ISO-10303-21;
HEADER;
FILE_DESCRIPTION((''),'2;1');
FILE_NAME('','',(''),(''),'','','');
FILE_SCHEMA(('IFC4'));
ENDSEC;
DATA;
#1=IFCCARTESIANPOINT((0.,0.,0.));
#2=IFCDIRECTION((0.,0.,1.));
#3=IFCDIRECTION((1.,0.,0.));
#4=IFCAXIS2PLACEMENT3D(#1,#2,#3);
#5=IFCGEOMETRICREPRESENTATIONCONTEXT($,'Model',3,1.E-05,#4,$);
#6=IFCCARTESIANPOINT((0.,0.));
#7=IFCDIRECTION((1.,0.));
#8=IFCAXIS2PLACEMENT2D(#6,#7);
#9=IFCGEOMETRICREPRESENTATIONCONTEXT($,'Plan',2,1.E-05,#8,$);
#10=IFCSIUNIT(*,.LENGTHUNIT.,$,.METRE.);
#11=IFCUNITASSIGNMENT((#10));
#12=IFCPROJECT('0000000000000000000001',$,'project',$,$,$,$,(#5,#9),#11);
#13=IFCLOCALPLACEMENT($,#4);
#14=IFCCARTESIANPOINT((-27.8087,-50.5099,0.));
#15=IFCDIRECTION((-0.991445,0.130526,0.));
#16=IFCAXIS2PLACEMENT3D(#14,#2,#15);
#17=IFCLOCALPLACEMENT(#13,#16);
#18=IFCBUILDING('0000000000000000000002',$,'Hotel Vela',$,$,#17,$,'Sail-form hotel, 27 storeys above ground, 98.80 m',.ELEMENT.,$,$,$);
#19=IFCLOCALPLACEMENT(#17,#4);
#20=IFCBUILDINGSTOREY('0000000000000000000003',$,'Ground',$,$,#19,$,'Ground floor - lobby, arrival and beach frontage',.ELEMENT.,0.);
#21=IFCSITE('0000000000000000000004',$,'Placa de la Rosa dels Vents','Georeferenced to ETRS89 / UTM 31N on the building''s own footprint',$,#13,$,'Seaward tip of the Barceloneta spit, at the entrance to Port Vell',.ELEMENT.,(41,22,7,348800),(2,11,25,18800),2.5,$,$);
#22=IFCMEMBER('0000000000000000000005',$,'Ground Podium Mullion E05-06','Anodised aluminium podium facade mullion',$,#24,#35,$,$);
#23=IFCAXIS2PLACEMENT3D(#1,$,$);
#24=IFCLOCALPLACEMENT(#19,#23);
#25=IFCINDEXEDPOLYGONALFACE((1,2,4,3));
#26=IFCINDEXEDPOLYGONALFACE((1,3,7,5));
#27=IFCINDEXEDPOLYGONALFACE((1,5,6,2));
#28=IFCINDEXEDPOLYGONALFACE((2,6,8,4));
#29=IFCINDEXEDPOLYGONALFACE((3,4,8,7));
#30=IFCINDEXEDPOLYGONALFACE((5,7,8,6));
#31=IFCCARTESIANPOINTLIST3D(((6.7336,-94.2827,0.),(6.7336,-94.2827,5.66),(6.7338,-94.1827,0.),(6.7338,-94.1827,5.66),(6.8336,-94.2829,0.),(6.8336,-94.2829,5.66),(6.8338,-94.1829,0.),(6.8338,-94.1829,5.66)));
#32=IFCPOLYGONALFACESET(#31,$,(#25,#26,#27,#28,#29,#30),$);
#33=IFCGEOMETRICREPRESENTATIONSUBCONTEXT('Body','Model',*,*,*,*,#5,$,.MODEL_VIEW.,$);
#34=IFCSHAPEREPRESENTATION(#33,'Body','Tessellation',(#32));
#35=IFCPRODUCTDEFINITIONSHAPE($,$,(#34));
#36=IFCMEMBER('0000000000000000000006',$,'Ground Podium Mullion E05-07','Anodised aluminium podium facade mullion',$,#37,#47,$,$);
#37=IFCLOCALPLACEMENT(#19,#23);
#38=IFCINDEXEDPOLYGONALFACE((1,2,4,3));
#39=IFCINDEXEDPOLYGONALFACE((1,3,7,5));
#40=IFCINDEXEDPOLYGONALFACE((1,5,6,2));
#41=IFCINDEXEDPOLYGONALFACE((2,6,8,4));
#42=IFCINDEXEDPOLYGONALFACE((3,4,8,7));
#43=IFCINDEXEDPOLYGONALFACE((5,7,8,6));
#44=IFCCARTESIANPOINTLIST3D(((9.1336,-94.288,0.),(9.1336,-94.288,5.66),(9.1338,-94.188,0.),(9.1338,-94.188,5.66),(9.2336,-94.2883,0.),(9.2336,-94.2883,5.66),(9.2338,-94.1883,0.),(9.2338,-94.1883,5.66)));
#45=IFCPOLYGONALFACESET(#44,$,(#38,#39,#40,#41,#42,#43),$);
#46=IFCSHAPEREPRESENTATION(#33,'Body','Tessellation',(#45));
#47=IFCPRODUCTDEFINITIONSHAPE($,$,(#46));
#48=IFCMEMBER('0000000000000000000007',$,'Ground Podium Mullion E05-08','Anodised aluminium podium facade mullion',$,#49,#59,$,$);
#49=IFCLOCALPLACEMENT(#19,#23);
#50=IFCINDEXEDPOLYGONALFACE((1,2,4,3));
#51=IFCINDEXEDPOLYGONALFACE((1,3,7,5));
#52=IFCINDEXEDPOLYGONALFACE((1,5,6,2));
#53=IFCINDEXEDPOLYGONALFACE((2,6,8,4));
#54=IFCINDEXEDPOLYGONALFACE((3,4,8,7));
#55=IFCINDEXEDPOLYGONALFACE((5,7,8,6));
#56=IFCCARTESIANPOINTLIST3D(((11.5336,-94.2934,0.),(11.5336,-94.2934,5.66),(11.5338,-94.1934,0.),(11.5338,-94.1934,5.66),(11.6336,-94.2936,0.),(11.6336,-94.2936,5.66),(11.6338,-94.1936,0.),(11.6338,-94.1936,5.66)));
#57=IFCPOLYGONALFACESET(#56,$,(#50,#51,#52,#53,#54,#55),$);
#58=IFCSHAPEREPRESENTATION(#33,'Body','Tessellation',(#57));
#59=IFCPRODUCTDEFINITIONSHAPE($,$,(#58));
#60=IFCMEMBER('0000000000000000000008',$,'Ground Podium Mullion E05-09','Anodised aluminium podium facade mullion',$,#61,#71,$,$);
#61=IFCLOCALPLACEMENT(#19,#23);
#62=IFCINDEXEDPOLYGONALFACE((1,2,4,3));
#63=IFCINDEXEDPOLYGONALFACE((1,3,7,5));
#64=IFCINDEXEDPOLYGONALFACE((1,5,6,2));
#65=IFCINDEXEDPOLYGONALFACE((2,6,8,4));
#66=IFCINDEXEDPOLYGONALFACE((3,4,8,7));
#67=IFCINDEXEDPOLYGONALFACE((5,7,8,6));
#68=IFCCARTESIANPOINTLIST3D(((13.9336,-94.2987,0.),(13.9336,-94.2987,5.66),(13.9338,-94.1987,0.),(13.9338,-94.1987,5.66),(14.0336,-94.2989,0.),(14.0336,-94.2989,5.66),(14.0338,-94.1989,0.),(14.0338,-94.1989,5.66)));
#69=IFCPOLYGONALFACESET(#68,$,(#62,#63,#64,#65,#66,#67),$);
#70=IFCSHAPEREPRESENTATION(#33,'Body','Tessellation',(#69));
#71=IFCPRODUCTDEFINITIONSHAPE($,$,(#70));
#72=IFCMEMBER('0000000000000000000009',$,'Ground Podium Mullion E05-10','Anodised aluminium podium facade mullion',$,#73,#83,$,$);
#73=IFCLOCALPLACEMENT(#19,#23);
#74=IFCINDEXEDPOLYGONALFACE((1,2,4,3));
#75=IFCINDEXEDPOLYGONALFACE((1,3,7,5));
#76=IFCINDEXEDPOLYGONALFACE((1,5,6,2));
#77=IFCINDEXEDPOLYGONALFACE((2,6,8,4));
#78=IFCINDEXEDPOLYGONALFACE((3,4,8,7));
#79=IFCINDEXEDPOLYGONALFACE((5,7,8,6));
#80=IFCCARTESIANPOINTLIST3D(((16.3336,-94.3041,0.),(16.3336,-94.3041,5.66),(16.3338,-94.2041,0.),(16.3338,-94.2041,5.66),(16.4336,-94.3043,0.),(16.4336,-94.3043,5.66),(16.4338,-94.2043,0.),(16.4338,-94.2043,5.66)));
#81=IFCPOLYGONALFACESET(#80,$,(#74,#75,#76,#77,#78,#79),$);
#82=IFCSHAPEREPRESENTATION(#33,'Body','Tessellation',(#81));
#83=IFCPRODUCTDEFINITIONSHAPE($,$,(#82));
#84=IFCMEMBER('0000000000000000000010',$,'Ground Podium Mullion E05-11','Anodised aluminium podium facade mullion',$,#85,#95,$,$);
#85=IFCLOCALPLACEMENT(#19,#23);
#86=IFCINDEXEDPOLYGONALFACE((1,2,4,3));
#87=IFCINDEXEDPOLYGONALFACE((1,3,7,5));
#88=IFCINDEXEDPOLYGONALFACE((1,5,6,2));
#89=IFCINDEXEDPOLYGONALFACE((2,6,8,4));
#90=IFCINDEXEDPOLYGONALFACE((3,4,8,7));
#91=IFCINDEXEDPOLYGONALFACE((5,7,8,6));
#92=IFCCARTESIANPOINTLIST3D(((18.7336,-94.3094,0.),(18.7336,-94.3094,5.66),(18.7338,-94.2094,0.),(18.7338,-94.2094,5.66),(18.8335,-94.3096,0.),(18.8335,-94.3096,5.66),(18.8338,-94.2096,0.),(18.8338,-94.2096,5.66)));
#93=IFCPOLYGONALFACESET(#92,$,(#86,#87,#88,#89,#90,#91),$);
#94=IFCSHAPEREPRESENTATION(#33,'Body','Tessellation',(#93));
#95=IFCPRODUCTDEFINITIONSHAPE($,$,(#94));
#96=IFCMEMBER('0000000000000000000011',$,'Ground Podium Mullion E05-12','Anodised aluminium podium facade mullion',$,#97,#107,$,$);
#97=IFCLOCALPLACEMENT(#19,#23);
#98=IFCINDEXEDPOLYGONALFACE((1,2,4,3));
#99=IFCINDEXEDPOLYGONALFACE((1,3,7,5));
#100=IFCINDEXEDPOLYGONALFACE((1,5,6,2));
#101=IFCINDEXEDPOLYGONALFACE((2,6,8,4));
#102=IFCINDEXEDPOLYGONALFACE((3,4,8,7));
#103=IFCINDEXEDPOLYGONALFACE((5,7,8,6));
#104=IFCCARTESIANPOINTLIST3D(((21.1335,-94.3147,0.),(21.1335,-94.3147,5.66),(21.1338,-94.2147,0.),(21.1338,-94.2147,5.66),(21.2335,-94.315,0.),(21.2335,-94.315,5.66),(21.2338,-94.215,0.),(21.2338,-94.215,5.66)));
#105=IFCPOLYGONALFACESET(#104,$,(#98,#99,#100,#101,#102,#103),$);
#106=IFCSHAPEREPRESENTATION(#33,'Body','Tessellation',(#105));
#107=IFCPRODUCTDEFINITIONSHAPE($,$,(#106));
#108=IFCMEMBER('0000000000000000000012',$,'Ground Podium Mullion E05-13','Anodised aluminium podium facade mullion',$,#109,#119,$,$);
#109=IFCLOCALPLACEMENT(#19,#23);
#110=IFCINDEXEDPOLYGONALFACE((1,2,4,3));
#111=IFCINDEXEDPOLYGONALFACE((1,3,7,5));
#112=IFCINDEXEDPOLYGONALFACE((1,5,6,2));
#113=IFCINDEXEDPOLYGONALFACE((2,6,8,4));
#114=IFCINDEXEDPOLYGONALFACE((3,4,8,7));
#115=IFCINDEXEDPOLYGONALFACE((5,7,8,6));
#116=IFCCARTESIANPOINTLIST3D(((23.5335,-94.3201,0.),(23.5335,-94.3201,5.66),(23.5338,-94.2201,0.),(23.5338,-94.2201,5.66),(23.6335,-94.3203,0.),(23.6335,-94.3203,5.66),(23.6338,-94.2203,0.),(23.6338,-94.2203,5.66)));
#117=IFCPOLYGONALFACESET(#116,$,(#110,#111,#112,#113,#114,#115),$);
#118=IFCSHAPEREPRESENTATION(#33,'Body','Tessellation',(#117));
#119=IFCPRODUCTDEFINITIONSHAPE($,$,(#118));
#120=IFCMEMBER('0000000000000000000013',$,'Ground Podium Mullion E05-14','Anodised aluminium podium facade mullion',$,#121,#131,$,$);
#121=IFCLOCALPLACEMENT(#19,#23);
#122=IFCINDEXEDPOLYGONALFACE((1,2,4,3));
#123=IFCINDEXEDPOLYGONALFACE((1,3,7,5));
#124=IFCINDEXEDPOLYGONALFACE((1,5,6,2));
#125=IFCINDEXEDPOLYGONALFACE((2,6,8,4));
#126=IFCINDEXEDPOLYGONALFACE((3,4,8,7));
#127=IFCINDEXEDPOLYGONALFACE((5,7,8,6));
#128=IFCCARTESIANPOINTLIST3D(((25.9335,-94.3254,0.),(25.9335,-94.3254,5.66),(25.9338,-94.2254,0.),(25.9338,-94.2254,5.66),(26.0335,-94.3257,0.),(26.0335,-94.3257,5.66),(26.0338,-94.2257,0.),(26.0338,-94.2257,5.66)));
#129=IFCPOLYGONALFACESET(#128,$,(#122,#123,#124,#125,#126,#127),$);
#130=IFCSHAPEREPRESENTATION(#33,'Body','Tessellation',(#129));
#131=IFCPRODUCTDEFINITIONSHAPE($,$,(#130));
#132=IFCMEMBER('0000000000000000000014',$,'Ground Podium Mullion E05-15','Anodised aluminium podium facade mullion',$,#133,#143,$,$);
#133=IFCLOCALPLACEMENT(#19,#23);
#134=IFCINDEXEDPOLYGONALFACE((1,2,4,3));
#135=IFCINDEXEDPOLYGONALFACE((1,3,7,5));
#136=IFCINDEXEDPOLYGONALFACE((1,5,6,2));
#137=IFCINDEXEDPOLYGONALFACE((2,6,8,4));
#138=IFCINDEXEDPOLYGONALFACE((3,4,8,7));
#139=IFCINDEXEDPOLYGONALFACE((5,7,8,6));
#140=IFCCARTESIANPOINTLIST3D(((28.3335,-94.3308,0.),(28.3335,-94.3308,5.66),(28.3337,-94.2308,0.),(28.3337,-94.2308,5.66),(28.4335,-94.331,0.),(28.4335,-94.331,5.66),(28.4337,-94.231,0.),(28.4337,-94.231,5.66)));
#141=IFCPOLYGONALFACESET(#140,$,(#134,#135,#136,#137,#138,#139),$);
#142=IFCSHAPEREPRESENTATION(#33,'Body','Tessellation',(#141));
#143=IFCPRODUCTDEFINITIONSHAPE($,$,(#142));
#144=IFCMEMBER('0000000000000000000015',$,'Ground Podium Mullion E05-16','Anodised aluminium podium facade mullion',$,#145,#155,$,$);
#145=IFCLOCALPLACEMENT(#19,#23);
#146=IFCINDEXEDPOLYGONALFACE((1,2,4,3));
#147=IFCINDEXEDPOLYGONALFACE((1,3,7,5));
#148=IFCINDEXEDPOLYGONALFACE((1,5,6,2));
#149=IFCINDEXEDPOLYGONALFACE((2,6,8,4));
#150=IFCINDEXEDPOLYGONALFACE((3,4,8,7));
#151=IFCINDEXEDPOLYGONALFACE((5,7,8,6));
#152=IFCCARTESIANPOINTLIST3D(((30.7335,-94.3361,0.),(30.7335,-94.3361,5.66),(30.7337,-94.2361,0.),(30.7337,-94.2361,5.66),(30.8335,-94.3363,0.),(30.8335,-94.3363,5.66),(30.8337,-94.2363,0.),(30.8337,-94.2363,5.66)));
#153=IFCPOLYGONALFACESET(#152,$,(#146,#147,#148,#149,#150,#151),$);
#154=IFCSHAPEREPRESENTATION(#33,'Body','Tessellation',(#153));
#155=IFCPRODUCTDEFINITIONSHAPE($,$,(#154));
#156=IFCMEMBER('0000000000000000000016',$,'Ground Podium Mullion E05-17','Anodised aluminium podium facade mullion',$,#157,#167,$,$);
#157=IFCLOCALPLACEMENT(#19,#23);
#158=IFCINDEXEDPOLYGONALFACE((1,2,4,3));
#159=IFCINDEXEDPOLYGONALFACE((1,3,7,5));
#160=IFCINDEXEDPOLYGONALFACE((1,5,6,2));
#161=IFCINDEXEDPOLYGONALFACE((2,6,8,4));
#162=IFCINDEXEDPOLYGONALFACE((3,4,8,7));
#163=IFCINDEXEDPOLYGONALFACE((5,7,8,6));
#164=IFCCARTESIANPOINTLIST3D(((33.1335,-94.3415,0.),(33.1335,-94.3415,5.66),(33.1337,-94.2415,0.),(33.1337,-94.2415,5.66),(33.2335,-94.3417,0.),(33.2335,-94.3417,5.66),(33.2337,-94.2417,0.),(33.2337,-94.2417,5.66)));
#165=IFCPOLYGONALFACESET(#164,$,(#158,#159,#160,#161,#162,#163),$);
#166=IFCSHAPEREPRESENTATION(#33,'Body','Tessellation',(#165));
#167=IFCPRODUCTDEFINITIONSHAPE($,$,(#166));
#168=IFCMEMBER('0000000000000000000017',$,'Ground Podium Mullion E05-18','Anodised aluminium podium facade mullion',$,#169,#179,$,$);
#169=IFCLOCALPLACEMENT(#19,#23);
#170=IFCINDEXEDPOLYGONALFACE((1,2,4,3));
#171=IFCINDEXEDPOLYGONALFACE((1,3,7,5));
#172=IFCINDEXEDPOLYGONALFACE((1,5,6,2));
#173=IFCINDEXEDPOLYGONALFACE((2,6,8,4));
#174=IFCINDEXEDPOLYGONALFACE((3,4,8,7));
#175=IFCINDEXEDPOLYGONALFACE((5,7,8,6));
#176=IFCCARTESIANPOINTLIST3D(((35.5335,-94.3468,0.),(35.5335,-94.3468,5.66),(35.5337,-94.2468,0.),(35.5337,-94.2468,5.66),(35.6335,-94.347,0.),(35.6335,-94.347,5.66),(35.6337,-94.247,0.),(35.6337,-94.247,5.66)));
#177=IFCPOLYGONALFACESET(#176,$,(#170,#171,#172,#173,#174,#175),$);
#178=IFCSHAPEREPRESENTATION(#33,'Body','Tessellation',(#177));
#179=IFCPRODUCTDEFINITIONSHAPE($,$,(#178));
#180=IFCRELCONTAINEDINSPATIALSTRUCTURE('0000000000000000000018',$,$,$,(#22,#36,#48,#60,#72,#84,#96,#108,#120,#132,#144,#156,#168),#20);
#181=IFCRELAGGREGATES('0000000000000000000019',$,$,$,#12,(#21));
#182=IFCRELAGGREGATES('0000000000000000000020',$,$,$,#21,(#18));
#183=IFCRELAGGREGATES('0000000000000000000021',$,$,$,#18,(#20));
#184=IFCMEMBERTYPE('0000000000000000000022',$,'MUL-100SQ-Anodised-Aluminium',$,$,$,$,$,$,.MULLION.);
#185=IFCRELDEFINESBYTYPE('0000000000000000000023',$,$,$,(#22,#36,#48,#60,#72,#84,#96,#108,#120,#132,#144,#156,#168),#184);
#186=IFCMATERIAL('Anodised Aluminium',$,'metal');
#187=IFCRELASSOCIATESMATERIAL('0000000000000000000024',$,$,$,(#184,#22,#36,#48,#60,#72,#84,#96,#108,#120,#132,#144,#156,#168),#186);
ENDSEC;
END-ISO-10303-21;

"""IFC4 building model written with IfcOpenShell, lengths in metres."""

from ifc_helpers import new_model, si_unit, frame, origin_with_axes, origin_2d_with_axis, place, context, subcontext, project, spatial, line, indexed_curve, rectangle, outline, extrude, material, material_profile, profile_set, profile_usage, type_object, element, save


model = new_model("IFC4")

# Units and contexts
model_context = context("Model", 3, precision=1e-05, world=origin_with_axes())
plan_context = context("Plan", 2, precision=1e-05, world=origin_2d_with_axis())
body_context = subcontext(model_context, "Body", "Model", "MODEL_VIEW")
ifc_project = project(units=[si_unit("LENGTHUNIT", "METRE")], contexts=[model_context, plan_context])

# Site, building, storey
site_placement = place(None, origin_with_axes())
site = spatial("IfcSite", under=ifc_project, at=site_placement, Name="Placa de la Rosa dels Vents", Description="Georeferenced to ETRS89 / UTM 31N on the building's own footprint", LongName="Seaward tip of the Barceloneta spit, at the entrance to Port Vell", CompositionType="ELEMENT", RefLatitude=(41, 22, 7, 348800), RefLongitude=(2, 11, 25, 18800), RefElevation=2.5)
building_placement = place(site_placement, frame((-27.8087, -50.5099, 0.0), z_axis=(0.0, 0.0, 1.0), x_axis=(-0.991445, 0.130526, 0.0)))
building = spatial("IfcBuilding", under=site, at=building_placement, Name="Hotel Vela", LongName="Sail-form hotel, 27 storeys above ground, 98.80 m", CompositionType="ELEMENT")
storey_placement = place(building_placement, origin_with_axes())
storey = spatial("IfcBuildingStorey", under=building, at=storey_placement, Name="Ground", LongName="Ground floor - lobby, arrival and beach frontage", CompositionType="ELEMENT", Elevation=0.0)

# Members
ifc_material = material(Name="Anodised Aluminium", Category="metal")
ifc_material_profile = material_profile(ifc_material, rectangle(XDim=0.1, YDim=0.1))
ifc_profile_set = profile_set([ifc_material_profile], Name="MUL-100SQ-Anodised-Aluminium")
ifc_profile_usage_1 = profile_usage(ifc_profile_set)
member_type = type_object("IfcMemberType", Name="MUL-100SQ-Anodised-Aluminium", PredefinedType="MULLION", material=ifc_profile_set)
member_1_placement = place(storey_placement, frame((6.7336, -94.2827, 0.0), z_axis=(0.0, 0.0, 1.0), x_axis=(0.999998, -0.002226, 0.0)))
element("IfcMember", 1, at=member_1_placement, inside=storey, type_object=member_type, material=ifc_profile_usage_1, Name="Ground Podium Mullion E05-06", Description="Anodised aluminium podium facade mullion", context=body_context, shape_type="SweptSolid", body=[
    extrude(outline(indexed_curve([(0.0, 0.0), (0.1, 0.0), (0.1, 0.1), (0.0, 0.1)], segments=[line(1, 2, 3, 4, 1)])), origin_with_axes(), (0.0, 0.0, 1.0), 5.66),
])
ifc_profile_usage_2 = profile_usage(ifc_profile_set)
member_2_placement = place(storey_placement, frame((9.1336, -94.288, 0.0), z_axis=(0.0, 0.0, 1.0), x_axis=(0.999998, -0.002226, 0.0)))
element("IfcMember", 2, at=member_2_placement, inside=storey, type_object=member_type, material=ifc_profile_usage_2, Name="Ground Podium Mullion E05-07", Description="Anodised aluminium podium facade mullion", context=body_context, shape_type="SweptSolid", body=[
    extrude(outline(indexed_curve([(0.0, 0.0), (0.1, 0.0), (0.1, 0.1), (0.0, 0.1)], segments=[line(1, 2, 3, 4, 1)])), origin_with_axes(), (0.0, 0.0, 1.0), 5.66),
])
ifc_profile_usage_3 = profile_usage(ifc_profile_set)
member_3_placement = place(storey_placement, frame((11.5336, -94.2934, 0.0), z_axis=(0.0, 0.0, 1.0), x_axis=(0.999998, -0.002226, 0.0)))
element("IfcMember", 3, at=member_3_placement, inside=storey, type_object=member_type, material=ifc_profile_usage_3, Name="Ground Podium Mullion E05-08", Description="Anodised aluminium podium facade mullion", context=body_context, shape_type="SweptSolid", body=[
    extrude(outline(indexed_curve([(0.0, 0.0), (0.1, 0.0), (0.1, 0.1), (0.0, 0.1)], segments=[line(1, 2, 3, 4, 1)])), origin_with_axes(), (0.0, 0.0, 1.0), 5.66),
])
ifc_profile_usage_4 = profile_usage(ifc_profile_set)
member_4_placement = place(storey_placement, frame((13.9336, -94.2987, 0.0), z_axis=(0.0, 0.0, 1.0), x_axis=(0.999998, -0.002226, 0.0)))
element("IfcMember", 4, at=member_4_placement, inside=storey, type_object=member_type, material=ifc_profile_usage_4, Name="Ground Podium Mullion E05-09", Description="Anodised aluminium podium facade mullion", context=body_context, shape_type="SweptSolid", body=[
    extrude(outline(indexed_curve([(0.0, 0.0), (0.1, 0.0), (0.1, 0.1), (0.0, 0.1)], segments=[line(1, 2, 3, 4, 1)])), origin_with_axes(), (0.0, 0.0, 1.0), 5.66),
])
ifc_profile_usage_5 = profile_usage(ifc_profile_set)
member_5_placement = place(storey_placement, frame((16.3336, -94.3041, 0.0), z_axis=(0.0, 0.0, 1.0), x_axis=(0.999998, -0.002226, 0.0)))
element("IfcMember", 5, at=member_5_placement, inside=storey, type_object=member_type, material=ifc_profile_usage_5, Name="Ground Podium Mullion E05-10", Description="Anodised aluminium podium facade mullion", context=body_context, shape_type="SweptSolid", body=[
    extrude(outline(indexed_curve([(0.0, 0.0), (0.1, 0.0), (0.1, 0.1), (0.0, 0.1)], segments=[line(1, 2, 3, 4, 1)])), origin_with_axes(), (0.0, 0.0, 1.0), 5.66),
])
ifc_profile_usage_6 = profile_usage(ifc_profile_set)
member_6_placement = place(storey_placement, frame((18.7336, -94.3094, 0.0), z_axis=(0.0, 0.0, 1.0), x_axis=(0.999998, -0.002226, 0.0)))
element("IfcMember", 6, at=member_6_placement, inside=storey, type_object=member_type, material=ifc_profile_usage_6, Name="Ground Podium Mullion E05-11", Description="Anodised aluminium podium facade mullion", context=body_context, shape_type="SweptSolid", body=[
    extrude(outline(indexed_curve([(0.0, 0.0), (0.1, 0.0), (0.1, 0.1), (0.0, 0.1)], segments=[line(1, 2, 3, 4, 1)])), origin_with_axes(), (0.0, 0.0, 1.0), 5.66),
])
ifc_profile_usage_7 = profile_usage(ifc_profile_set)
member_7_placement = place(storey_placement, frame((21.1335, -94.3147, 0.0), z_axis=(0.0, 0.0, 1.0), x_axis=(0.999998, -0.002226, 0.0)))
element("IfcMember", 7, at=member_7_placement, inside=storey, type_object=member_type, material=ifc_profile_usage_7, Name="Ground Podium Mullion E05-12", Description="Anodised aluminium podium facade mullion", context=body_context, shape_type="SweptSolid", body=[
    extrude(outline(indexed_curve([(0.0, 0.0), (0.1, 0.0), (0.1, 0.1), (0.0, 0.1)], segments=[line(1, 2, 3, 4, 1)])), origin_with_axes(), (0.0, 0.0, 1.0), 5.66),
])
ifc_profile_usage_8 = profile_usage(ifc_profile_set)
member_8_placement = place(storey_placement, frame((23.5335, -94.3201, 0.0), z_axis=(0.0, 0.0, 1.0), x_axis=(0.999998, -0.002226, 0.0)))
element("IfcMember", 8, at=member_8_placement, inside=storey, type_object=member_type, material=ifc_profile_usage_8, Name="Ground Podium Mullion E05-13", Description="Anodised aluminium podium facade mullion", context=body_context, shape_type="SweptSolid", body=[
    extrude(outline(indexed_curve([(0.0, 0.0), (0.1, 0.0), (0.1, 0.1), (0.0, 0.1)], segments=[line(1, 2, 3, 4, 1)])), origin_with_axes(), (0.0, 0.0, 1.0), 5.66),
])
ifc_profile_usage_9 = profile_usage(ifc_profile_set)
member_9_placement = place(storey_placement, frame((25.9335, -94.3254, 0.0), z_axis=(0.0, 0.0, 1.0), x_axis=(0.999998, -0.002226, 0.0)))
element("IfcMember", 9, at=member_9_placement, inside=storey, type_object=member_type, material=ifc_profile_usage_9, Name="Ground Podium Mullion E05-14", Description="Anodised aluminium podium facade mullion", context=body_context, shape_type="SweptSolid", body=[
    extrude(outline(indexed_curve([(0.0, 0.0), (0.1, 0.0), (0.1, 0.1), (0.0, 0.1)], segments=[line(1, 2, 3, 4, 1)])), origin_with_axes(), (0.0, 0.0, 1.0), 5.66),
])
ifc_profile_usage_10 = profile_usage(ifc_profile_set)
member_10_placement = place(storey_placement, frame((28.3335, -94.3308, 0.0), z_axis=(0.0, 0.0, 1.0), x_axis=(0.999998, -0.002226, 0.0)))
element("IfcMember", 10, at=member_10_placement, inside=storey, type_object=member_type, material=ifc_profile_usage_10, Name="Ground Podium Mullion E05-15", Description="Anodised aluminium podium facade mullion", context=body_context, shape_type="SweptSolid", body=[
    extrude(outline(indexed_curve([(0.0, 0.0), (0.1, 0.0), (0.1, 0.1), (0.0, 0.1)], segments=[line(1, 2, 3, 4, 1)])), origin_with_axes(), (0.0, 0.0, 1.0), 5.66),
])
ifc_profile_usage_11 = profile_usage(ifc_profile_set)
member_11_placement = place(storey_placement, frame((30.7335, -94.3361, 0.0), z_axis=(0.0, 0.0, 1.0), x_axis=(0.999998, -0.002226, 0.0)))
element("IfcMember", 11, at=member_11_placement, inside=storey, type_object=member_type, material=ifc_profile_usage_11, Name="Ground Podium Mullion E05-16", Description="Anodised aluminium podium facade mullion", context=body_context, shape_type="SweptSolid", body=[
    extrude(outline(indexed_curve([(0.0, 0.0), (0.1, 0.0), (0.1, 0.1), (0.0, 0.1)], segments=[line(1, 2, 3, 4, 1)])), origin_with_axes(), (0.0, 0.0, 1.0), 5.66),
])
ifc_profile_usage_12 = profile_usage(ifc_profile_set)
member_12_placement = place(storey_placement, frame((33.1335, -94.3415, 0.0), z_axis=(0.0, 0.0, 1.0), x_axis=(0.999998, -0.002226, 0.0)))
element("IfcMember", 12, at=member_12_placement, inside=storey, type_object=member_type, material=ifc_profile_usage_12, Name="Ground Podium Mullion E05-17", Description="Anodised aluminium podium facade mullion", context=body_context, shape_type="SweptSolid", body=[
    extrude(outline(indexed_curve([(0.0, 0.0), (0.1, 0.0), (0.1, 0.1), (0.0, 0.1)], segments=[line(1, 2, 3, 4, 1)])), origin_with_axes(), (0.0, 0.0, 1.0), 5.66),
])
ifc_profile_usage_13 = profile_usage(ifc_profile_set)
member_13_placement = place(storey_placement, frame((35.5335, -94.3468, 0.0), z_axis=(0.0, 0.0, 1.0), x_axis=(0.999998, -0.002226, 0.0)))
element("IfcMember", 13, at=member_13_placement, inside=storey, type_object=member_type, material=ifc_profile_usage_13, Name="Ground Podium Mullion E05-18", Description="Anodised aluminium podium facade mullion", context=body_context, shape_type="SweptSolid", body=[
    extrude(outline(indexed_curve([(0.0, 0.0), (0.1, 0.0), (0.1, 0.1), (0.0, 0.1)], segments=[line(1, 2, 3, 4, 1)])), origin_with_axes(), (0.0, 0.0, 1.0), 5.66),
])

save(model, "model.ifc")
